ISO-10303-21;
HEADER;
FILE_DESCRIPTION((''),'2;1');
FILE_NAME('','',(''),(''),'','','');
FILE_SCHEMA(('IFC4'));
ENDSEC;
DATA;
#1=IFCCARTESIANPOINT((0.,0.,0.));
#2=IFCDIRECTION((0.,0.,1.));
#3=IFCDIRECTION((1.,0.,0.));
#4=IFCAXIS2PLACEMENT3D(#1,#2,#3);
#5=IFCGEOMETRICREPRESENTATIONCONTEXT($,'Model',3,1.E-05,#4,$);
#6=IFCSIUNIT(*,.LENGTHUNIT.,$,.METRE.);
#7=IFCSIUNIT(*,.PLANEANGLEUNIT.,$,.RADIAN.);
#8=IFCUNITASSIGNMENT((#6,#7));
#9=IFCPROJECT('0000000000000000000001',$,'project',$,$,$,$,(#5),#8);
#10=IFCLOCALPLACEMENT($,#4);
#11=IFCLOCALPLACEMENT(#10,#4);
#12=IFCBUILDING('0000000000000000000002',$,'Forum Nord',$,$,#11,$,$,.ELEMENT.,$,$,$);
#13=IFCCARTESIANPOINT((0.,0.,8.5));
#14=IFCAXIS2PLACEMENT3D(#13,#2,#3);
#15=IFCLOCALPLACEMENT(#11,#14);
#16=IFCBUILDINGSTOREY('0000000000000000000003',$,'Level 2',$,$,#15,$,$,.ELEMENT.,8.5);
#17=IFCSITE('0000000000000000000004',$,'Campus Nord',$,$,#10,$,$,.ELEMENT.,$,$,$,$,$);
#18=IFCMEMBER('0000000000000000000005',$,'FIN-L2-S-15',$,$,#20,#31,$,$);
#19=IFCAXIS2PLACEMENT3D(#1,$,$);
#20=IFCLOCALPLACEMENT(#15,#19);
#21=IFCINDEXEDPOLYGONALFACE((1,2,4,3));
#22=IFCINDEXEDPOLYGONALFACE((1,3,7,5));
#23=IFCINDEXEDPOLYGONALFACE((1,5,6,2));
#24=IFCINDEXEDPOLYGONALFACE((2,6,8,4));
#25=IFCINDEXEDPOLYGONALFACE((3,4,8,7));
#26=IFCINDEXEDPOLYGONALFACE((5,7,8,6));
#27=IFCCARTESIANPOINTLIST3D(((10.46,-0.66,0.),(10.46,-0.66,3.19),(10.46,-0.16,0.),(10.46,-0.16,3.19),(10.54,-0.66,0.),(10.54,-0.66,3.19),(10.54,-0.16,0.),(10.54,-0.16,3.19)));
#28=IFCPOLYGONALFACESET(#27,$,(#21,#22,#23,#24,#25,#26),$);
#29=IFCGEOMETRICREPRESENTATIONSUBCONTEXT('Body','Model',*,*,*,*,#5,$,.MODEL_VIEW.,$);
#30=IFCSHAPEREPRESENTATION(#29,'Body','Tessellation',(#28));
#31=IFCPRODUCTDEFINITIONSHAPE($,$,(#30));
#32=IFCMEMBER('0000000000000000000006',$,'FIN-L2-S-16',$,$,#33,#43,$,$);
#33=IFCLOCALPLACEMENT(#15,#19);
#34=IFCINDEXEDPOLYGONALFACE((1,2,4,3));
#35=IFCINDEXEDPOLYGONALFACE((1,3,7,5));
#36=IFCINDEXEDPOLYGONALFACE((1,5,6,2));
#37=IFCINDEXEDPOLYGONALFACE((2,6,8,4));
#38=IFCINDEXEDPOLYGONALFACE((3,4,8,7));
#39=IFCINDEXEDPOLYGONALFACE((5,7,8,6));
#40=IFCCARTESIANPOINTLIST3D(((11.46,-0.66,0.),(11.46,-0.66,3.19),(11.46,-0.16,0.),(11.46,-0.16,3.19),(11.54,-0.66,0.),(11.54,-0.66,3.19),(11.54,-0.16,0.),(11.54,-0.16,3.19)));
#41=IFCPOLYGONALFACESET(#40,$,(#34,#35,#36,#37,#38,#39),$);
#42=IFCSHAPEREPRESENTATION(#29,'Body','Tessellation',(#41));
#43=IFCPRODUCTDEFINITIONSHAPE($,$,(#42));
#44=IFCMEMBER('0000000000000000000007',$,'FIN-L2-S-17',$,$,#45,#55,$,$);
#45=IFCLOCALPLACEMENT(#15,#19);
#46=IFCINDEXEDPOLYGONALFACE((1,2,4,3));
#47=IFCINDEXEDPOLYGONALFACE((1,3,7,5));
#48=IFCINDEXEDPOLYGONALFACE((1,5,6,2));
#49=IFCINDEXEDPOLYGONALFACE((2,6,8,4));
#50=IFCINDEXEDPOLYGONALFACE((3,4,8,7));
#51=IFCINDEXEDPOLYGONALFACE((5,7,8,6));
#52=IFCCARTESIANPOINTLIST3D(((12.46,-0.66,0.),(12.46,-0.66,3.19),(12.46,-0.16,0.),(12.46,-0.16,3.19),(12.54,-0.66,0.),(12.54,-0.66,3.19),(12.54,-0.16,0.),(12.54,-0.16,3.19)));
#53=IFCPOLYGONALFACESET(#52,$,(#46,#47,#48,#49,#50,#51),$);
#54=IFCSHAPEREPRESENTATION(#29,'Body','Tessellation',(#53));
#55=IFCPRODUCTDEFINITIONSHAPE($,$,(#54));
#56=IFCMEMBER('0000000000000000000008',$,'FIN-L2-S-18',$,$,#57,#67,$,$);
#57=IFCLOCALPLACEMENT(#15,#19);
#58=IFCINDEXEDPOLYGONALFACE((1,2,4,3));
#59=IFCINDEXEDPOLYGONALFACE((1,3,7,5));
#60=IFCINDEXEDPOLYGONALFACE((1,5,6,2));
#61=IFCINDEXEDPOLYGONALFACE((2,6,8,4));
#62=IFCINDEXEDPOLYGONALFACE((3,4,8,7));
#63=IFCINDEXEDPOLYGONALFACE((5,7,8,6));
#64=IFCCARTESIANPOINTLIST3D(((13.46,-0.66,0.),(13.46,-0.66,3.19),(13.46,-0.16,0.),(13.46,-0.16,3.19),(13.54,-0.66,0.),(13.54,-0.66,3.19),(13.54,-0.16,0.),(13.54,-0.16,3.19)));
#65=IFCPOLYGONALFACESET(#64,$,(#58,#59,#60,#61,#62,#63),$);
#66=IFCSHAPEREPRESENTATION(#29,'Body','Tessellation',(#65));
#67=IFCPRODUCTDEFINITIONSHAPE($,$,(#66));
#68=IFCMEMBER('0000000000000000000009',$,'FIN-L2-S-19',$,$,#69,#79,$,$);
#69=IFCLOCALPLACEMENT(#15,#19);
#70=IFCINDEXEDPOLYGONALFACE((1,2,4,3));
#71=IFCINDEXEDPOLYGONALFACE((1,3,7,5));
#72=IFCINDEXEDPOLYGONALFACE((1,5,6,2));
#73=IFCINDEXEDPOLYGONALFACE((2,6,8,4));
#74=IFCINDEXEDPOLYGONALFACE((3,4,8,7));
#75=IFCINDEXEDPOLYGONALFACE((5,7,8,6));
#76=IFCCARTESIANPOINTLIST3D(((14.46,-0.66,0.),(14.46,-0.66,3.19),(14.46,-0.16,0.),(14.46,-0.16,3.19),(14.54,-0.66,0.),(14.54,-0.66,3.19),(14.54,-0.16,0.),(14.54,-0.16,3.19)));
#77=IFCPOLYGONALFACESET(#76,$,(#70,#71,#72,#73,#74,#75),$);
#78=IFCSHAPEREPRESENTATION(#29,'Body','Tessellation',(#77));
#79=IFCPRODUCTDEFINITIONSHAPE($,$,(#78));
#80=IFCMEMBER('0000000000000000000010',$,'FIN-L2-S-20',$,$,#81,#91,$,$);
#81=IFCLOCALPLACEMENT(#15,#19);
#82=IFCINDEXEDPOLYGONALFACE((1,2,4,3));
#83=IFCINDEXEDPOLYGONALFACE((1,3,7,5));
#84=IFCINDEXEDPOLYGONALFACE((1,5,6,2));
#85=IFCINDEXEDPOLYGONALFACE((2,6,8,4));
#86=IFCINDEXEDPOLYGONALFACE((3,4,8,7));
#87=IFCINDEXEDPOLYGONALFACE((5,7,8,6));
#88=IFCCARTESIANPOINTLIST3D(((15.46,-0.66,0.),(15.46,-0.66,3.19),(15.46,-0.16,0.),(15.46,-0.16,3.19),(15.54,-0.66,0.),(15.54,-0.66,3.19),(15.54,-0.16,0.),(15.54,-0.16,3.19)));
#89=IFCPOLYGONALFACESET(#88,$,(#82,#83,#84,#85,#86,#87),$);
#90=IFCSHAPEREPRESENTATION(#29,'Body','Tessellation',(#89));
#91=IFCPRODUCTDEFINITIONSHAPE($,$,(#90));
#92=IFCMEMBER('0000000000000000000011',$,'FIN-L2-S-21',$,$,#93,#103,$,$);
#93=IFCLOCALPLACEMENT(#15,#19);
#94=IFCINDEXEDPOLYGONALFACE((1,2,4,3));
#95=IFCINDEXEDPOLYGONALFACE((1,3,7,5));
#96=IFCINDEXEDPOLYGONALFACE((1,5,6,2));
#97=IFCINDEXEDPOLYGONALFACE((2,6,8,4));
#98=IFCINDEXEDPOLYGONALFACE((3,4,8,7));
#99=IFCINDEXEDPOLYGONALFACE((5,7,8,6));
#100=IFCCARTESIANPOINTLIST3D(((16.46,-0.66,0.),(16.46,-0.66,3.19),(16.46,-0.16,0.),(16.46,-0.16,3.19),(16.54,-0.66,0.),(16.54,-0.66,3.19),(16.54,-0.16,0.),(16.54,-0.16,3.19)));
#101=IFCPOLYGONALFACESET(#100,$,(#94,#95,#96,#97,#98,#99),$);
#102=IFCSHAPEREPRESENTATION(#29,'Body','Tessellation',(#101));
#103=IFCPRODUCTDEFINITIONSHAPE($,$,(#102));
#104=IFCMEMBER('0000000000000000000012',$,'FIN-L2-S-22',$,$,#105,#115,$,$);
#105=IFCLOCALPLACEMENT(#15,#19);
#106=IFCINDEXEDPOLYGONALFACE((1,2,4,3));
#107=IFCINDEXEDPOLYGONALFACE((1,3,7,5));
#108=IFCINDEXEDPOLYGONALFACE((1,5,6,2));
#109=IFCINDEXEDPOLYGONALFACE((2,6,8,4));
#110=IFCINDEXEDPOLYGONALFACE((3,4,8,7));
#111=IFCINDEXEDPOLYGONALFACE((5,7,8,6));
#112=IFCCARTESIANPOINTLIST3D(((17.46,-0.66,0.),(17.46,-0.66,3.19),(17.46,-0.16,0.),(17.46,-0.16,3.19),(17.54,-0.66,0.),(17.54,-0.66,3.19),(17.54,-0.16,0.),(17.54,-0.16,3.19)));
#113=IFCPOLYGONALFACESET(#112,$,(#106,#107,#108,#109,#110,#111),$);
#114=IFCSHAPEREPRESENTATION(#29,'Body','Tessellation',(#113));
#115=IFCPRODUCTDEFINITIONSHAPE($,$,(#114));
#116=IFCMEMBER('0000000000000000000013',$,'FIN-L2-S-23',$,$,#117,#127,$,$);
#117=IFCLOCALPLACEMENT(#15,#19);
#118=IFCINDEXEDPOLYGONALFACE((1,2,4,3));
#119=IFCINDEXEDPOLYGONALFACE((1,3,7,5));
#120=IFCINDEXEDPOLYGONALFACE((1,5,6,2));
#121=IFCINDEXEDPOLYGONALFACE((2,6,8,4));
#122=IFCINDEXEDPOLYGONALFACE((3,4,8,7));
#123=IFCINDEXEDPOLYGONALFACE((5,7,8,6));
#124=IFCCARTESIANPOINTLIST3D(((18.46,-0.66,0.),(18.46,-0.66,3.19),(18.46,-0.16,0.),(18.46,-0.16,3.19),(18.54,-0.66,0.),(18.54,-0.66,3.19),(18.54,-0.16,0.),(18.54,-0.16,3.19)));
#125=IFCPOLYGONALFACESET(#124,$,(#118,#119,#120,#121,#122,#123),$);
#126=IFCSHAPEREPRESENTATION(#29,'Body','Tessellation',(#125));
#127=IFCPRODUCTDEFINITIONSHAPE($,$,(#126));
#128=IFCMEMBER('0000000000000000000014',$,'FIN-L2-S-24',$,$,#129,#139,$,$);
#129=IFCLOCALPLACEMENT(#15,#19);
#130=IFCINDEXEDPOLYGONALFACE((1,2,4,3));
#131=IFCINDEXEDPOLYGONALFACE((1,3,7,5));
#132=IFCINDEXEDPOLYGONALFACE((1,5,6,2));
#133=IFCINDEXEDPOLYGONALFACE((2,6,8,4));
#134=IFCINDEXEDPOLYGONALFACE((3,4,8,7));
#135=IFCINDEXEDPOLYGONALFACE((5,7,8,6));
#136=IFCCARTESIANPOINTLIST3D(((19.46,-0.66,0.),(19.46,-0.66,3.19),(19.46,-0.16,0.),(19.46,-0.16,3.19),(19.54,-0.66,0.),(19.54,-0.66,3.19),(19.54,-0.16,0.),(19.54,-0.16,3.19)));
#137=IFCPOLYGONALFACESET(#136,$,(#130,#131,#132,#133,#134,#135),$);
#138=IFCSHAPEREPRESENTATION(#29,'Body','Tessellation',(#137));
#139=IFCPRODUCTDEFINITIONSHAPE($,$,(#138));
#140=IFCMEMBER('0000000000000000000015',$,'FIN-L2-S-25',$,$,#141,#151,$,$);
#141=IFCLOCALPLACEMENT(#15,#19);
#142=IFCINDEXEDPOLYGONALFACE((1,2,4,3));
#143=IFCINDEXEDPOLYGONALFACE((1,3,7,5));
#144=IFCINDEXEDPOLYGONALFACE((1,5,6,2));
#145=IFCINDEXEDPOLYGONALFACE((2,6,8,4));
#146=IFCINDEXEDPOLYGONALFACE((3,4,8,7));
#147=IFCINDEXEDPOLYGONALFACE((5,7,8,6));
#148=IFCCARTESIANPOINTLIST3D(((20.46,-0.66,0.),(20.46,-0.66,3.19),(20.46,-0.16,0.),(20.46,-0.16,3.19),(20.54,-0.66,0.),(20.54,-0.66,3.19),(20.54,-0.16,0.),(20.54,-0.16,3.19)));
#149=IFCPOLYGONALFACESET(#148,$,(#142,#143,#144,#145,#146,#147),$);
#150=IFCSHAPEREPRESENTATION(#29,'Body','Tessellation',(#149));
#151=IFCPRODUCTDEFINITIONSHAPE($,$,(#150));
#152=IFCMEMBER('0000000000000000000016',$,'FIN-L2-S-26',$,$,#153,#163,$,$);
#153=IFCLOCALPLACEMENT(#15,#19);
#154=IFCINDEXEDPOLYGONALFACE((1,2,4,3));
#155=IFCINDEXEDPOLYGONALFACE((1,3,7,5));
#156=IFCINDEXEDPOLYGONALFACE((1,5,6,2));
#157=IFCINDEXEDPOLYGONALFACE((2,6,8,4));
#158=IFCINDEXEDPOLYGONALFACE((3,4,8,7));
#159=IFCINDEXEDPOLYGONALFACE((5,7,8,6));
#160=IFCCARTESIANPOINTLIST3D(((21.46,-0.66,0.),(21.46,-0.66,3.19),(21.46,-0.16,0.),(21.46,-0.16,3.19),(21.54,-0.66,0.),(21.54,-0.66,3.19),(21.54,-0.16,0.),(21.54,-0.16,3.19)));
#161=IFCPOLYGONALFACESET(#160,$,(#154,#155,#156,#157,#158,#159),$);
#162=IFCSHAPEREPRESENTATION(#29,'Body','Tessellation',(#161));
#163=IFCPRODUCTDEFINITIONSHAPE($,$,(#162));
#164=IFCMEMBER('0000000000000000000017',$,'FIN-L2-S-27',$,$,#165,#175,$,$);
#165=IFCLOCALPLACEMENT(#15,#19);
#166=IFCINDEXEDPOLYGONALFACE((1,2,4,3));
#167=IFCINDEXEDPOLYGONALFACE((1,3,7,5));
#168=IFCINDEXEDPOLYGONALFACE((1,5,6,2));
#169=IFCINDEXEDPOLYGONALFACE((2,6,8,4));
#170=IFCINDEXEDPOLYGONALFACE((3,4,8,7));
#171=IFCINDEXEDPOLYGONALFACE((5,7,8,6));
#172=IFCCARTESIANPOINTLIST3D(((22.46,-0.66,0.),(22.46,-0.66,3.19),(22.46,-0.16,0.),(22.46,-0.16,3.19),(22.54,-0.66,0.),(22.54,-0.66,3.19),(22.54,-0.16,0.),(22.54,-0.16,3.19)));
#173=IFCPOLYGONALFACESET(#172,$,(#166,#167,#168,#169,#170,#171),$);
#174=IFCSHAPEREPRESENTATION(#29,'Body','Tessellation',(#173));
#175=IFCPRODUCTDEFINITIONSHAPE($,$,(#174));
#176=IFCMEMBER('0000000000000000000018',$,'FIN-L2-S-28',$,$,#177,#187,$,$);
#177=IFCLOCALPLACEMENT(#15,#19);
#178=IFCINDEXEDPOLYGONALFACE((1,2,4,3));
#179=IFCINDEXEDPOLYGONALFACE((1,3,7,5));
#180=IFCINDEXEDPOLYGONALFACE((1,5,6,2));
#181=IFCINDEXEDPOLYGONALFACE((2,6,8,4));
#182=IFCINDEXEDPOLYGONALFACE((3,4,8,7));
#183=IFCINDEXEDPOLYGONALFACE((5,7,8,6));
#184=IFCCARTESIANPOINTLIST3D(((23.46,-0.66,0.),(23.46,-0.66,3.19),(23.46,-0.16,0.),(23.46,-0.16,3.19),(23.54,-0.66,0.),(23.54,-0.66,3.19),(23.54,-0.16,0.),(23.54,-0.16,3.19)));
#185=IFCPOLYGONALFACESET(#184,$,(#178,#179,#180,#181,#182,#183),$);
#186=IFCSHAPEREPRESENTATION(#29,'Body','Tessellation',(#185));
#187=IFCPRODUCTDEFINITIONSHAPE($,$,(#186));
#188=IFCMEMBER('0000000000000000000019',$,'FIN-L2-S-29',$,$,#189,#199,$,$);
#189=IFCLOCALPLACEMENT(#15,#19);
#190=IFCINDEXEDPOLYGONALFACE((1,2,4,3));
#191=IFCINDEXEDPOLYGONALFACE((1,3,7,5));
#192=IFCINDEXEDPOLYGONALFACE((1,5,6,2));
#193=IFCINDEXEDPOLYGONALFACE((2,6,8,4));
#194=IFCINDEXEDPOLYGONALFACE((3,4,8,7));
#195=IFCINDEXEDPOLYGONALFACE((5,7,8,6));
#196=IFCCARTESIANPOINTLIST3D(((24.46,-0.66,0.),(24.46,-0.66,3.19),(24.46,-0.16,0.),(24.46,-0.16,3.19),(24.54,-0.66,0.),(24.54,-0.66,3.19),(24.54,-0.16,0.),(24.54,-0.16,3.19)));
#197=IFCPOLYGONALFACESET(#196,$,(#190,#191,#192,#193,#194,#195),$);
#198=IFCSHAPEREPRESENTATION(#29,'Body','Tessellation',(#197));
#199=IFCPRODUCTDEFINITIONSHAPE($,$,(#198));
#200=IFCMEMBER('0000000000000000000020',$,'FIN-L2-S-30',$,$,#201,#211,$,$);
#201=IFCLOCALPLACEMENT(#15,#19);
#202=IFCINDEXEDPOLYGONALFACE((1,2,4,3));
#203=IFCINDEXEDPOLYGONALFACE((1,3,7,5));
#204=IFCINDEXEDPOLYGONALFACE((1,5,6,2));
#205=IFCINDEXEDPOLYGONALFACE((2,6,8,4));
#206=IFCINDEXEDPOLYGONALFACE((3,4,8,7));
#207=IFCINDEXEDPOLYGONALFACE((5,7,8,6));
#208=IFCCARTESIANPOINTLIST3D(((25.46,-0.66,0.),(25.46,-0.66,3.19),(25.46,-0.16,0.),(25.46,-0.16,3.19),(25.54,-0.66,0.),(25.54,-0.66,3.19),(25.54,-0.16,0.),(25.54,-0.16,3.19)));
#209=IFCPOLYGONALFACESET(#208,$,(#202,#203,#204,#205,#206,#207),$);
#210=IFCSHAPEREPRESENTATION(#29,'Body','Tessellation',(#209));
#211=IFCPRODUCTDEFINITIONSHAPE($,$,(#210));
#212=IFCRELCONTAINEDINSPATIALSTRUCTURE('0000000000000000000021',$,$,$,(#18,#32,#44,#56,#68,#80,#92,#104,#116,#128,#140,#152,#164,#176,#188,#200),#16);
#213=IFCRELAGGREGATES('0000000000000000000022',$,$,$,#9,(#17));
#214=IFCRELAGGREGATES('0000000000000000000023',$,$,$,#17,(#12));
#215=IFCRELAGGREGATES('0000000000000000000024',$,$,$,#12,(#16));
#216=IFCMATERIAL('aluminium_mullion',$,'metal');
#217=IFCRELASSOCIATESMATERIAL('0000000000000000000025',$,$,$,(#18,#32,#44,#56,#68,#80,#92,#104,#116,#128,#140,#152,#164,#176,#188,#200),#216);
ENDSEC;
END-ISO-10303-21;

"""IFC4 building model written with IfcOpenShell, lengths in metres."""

from ifc_helpers import new_model, si_unit, frame, origin_with_axes, place, context, subcontext, project, spatial, polyline, outline, extrude, material, element, save


model = new_model("IFC4")

# Units and contexts
model_context = context("Model", 3, precision=1e-05, world=origin_with_axes())
body_context = subcontext(model_context, "Body", "Model", "MODEL_VIEW")
ifc_project = project(units=[si_unit("LENGTHUNIT", "METRE"), si_unit("PLANEANGLEUNIT", "RADIAN")], contexts=[model_context])

# Site, building, storey
site_placement = place(None, origin_with_axes())
site = spatial("IfcSite", under=ifc_project, at=site_placement, Name="Campus Nord", CompositionType="ELEMENT")
building_placement = place(site_placement, origin_with_axes())
building = spatial("IfcBuilding", under=site, at=building_placement, Name="Forum Nord", CompositionType="ELEMENT")
storey_placement = place(building_placement, frame((0.0, 0.0, 8.5), z_axis=(0.0, 0.0, 1.0), x_axis=(1.0, 0.0, 0.0)))
storey = spatial("IfcBuildingStorey", under=building, at=storey_placement, Name="Level 2", CompositionType="ELEMENT", Elevation=8.5)

# Members
ifc_material = material(Name="aluminium_mullion", Category="metal")
member_1_placement = place(storey_placement, origin_with_axes())
element("IfcMember", 1, at=member_1_placement, inside=storey, material=ifc_material, Name="FIN-L2-S-15", context=body_context, shape_type="SweptSolid", body=[
    extrude(outline(polyline([(10.46, -0.66), (10.54, -0.66), (10.54, -0.16), (10.46, -0.16), (10.46, -0.66)])), origin_with_axes(), (0.0, 0.0, 1.0), 3.19),
])
member_2_placement = place(storey_placement, origin_with_axes())
element("IfcMember", 2, at=member_2_placement, inside=storey, material=ifc_material, Name="FIN-L2-S-16", context=body_context, shape_type="SweptSolid", body=[
    extrude(outline(polyline([(11.46, -0.66), (11.54, -0.66), (11.54, -0.16), (11.46, -0.16), (11.46, -0.66)])), origin_with_axes(), (0.0, 0.0, 1.0), 3.19),
])
member_3_placement = place(storey_placement, origin_with_axes())
element("IfcMember", 3, at=member_3_placement, inside=storey, material=ifc_material, Name="FIN-L2-S-17", context=body_context, shape_type="SweptSolid", body=[
    extrude(outline(polyline([(12.46, -0.66), (12.54, -0.66), (12.54, -0.16), (12.46, -0.16), (12.46, -0.66)])), origin_with_axes(), (0.0, 0.0, 1.0), 3.19),
])
member_4_placement = place(storey_placement, origin_with_axes())
element("IfcMember", 4, at=member_4_placement, inside=storey, material=ifc_material, Name="FIN-L2-S-18", context=body_context, shape_type="SweptSolid", body=[
    extrude(outline(polyline([(13.46, -0.66), (13.54, -0.66), (13.54, -0.16), (13.46, -0.16), (13.46, -0.66)])), origin_with_axes(), (0.0, 0.0, 1.0), 3.19),
])
member_5_placement = place(storey_placement, origin_with_axes())
element("IfcMember", 5, at=member_5_placement, inside=storey, material=ifc_material, Name="FIN-L2-S-19", context=body_context, shape_type="SweptSolid", body=[
    extrude(outline(polyline([(14.46, -0.66), (14.54, -0.66), (14.54, -0.16), (14.46, -0.16), (14.46, -0.66)])), origin_with_axes(), (0.0, 0.0, 1.0), 3.19),
])
member_6_placement = place(storey_placement, origin_with_axes())
element("IfcMember", 6, at=member_6_placement, inside=storey, material=ifc_material, Name="FIN-L2-S-20", context=body_context, shape_type="SweptSolid", body=[
    extrude(outline(polyline([(15.46, -0.66), (15.54, -0.66), (15.54, -0.16), (15.46, -0.16), (15.46, -0.66)])), origin_with_axes(), (0.0, 0.0, 1.0), 3.19),
])
member_7_placement = place(storey_placement, origin_with_axes())
element("IfcMember", 7, at=member_7_placement, inside=storey, material=ifc_material, Name="FIN-L2-S-21", context=body_context, shape_type="SweptSolid", body=[
    extrude(outline(polyline([(16.46, -0.66), (16.54, -0.66), (16.54, -0.16), (16.46, -0.16), (16.46, -0.66)])), origin_with_axes(), (0.0, 0.0, 1.0), 3.19),
])
member_8_placement = place(storey_placement, origin_with_axes())
element("IfcMember", 8, at=member_8_placement, inside=storey, material=ifc_material, Name="FIN-L2-S-22", context=body_context, shape_type="SweptSolid", body=[
    extrude(outline(polyline([(17.46, -0.66), (17.54, -0.66), (17.54, -0.16), (17.46, -0.16), (17.46, -0.66)])), origin_with_axes(), (0.0, 0.0, 1.0), 3.19),
])
member_9_placement = place(storey_placement, origin_with_axes())
element("IfcMember", 9, at=member_9_placement, inside=storey, material=ifc_material, Name="FIN-L2-S-23", context=body_context, shape_type="SweptSolid", body=[
    extrude(outline(polyline([(18.46, -0.66), (18.54, -0.66), (18.54, -0.16), (18.46, -0.16), (18.46, -0.66)])), origin_with_axes(), (0.0, 0.0, 1.0), 3.19),
])
member_10_placement = place(storey_placement, origin_with_axes())
element("IfcMember", 10, at=member_10_placement, inside=storey, material=ifc_material, Name="FIN-L2-S-24", context=body_context, shape_type="SweptSolid", body=[
    extrude(outline(polyline([(19.46, -0.66), (19.54, -0.66), (19.54, -0.16), (19.46, -0.16), (19.46, -0.66)])), origin_with_axes(), (0.0, 0.0, 1.0), 3.19),
])
member_11_placement = place(storey_placement, origin_with_axes())
element("IfcMember", 11, at=member_11_placement, inside=storey, material=ifc_material, Name="FIN-L2-S-25", context=body_context, shape_type="SweptSolid", body=[
    extrude(outline(polyline([(20.46, -0.66), (20.54, -0.66), (20.54, -0.16), (20.46, -0.16), (20.46, -0.66)])), origin_with_axes(), (0.0, 0.0, 1.0), 3.19),
])
member_12_placement = place(storey_placement, origin_with_axes())
element("IfcMember", 12, at=member_12_placement, inside=storey, material=ifc_material, Name="FIN-L2-S-26", context=body_context, shape_type="SweptSolid", body=[
    extrude(outline(polyline([(21.46, -0.66), (21.54, -0.66), (21.54, -0.16), (21.46, -0.16), (21.46, -0.66)])), origin_with_axes(), (0.0, 0.0, 1.0), 3.19),
])
member_13_placement = place(storey_placement, origin_with_axes())
element("IfcMember", 13, at=member_13_placement, inside=storey, material=ifc_material, Name="FIN-L2-S-27", context=body_context, shape_type="SweptSolid", body=[
    extrude(outline(polyline([(22.46, -0.66), (22.54, -0.66), (22.54, -0.16), (22.46, -0.16), (22.46, -0.66)])), origin_with_axes(), (0.0, 0.0, 1.0), 3.19),
])
member_14_placement = place(storey_placement, origin_with_axes())
element("IfcMember", 14, at=member_14_placement, inside=storey, material=ifc_material, Name="FIN-L2-S-28", context=body_context, shape_type="SweptSolid", body=[
    extrude(outline(polyline([(23.46, -0.66), (23.54, -0.66), (23.54, -0.16), (23.46, -0.16), (23.46, -0.66)])), origin_with_axes(), (0.0, 0.0, 1.0), 3.19),
])
member_15_placement = place(storey_placement, origin_with_axes())
element("IfcMember", 15, at=member_15_placement, inside=storey, material=ifc_material, Name="FIN-L2-S-29", context=body_context, shape_type="SweptSolid", body=[
    extrude(outline(polyline([(24.46, -0.66), (24.54, -0.66), (24.54, -0.16), (24.46, -0.16), (24.46, -0.66)])), origin_with_axes(), (0.0, 0.0, 1.0), 3.19),
])
member_16_placement = place(storey_placement, origin_with_axes())
element("IfcMember", 16, at=member_16_placement, inside=storey, material=ifc_material, Name="FIN-L2-S-30", context=body_context, shape_type="SweptSolid", body=[
    extrude(outline(polyline([(25.46, -0.66), (25.54, -0.66), (25.54, -0.16), (25.46, -0.16), (25.46, -0.66)])), origin_with_axes(), (0.0, 0.0, 1.0), 3.19),
])

save(model, "model.ifc")
